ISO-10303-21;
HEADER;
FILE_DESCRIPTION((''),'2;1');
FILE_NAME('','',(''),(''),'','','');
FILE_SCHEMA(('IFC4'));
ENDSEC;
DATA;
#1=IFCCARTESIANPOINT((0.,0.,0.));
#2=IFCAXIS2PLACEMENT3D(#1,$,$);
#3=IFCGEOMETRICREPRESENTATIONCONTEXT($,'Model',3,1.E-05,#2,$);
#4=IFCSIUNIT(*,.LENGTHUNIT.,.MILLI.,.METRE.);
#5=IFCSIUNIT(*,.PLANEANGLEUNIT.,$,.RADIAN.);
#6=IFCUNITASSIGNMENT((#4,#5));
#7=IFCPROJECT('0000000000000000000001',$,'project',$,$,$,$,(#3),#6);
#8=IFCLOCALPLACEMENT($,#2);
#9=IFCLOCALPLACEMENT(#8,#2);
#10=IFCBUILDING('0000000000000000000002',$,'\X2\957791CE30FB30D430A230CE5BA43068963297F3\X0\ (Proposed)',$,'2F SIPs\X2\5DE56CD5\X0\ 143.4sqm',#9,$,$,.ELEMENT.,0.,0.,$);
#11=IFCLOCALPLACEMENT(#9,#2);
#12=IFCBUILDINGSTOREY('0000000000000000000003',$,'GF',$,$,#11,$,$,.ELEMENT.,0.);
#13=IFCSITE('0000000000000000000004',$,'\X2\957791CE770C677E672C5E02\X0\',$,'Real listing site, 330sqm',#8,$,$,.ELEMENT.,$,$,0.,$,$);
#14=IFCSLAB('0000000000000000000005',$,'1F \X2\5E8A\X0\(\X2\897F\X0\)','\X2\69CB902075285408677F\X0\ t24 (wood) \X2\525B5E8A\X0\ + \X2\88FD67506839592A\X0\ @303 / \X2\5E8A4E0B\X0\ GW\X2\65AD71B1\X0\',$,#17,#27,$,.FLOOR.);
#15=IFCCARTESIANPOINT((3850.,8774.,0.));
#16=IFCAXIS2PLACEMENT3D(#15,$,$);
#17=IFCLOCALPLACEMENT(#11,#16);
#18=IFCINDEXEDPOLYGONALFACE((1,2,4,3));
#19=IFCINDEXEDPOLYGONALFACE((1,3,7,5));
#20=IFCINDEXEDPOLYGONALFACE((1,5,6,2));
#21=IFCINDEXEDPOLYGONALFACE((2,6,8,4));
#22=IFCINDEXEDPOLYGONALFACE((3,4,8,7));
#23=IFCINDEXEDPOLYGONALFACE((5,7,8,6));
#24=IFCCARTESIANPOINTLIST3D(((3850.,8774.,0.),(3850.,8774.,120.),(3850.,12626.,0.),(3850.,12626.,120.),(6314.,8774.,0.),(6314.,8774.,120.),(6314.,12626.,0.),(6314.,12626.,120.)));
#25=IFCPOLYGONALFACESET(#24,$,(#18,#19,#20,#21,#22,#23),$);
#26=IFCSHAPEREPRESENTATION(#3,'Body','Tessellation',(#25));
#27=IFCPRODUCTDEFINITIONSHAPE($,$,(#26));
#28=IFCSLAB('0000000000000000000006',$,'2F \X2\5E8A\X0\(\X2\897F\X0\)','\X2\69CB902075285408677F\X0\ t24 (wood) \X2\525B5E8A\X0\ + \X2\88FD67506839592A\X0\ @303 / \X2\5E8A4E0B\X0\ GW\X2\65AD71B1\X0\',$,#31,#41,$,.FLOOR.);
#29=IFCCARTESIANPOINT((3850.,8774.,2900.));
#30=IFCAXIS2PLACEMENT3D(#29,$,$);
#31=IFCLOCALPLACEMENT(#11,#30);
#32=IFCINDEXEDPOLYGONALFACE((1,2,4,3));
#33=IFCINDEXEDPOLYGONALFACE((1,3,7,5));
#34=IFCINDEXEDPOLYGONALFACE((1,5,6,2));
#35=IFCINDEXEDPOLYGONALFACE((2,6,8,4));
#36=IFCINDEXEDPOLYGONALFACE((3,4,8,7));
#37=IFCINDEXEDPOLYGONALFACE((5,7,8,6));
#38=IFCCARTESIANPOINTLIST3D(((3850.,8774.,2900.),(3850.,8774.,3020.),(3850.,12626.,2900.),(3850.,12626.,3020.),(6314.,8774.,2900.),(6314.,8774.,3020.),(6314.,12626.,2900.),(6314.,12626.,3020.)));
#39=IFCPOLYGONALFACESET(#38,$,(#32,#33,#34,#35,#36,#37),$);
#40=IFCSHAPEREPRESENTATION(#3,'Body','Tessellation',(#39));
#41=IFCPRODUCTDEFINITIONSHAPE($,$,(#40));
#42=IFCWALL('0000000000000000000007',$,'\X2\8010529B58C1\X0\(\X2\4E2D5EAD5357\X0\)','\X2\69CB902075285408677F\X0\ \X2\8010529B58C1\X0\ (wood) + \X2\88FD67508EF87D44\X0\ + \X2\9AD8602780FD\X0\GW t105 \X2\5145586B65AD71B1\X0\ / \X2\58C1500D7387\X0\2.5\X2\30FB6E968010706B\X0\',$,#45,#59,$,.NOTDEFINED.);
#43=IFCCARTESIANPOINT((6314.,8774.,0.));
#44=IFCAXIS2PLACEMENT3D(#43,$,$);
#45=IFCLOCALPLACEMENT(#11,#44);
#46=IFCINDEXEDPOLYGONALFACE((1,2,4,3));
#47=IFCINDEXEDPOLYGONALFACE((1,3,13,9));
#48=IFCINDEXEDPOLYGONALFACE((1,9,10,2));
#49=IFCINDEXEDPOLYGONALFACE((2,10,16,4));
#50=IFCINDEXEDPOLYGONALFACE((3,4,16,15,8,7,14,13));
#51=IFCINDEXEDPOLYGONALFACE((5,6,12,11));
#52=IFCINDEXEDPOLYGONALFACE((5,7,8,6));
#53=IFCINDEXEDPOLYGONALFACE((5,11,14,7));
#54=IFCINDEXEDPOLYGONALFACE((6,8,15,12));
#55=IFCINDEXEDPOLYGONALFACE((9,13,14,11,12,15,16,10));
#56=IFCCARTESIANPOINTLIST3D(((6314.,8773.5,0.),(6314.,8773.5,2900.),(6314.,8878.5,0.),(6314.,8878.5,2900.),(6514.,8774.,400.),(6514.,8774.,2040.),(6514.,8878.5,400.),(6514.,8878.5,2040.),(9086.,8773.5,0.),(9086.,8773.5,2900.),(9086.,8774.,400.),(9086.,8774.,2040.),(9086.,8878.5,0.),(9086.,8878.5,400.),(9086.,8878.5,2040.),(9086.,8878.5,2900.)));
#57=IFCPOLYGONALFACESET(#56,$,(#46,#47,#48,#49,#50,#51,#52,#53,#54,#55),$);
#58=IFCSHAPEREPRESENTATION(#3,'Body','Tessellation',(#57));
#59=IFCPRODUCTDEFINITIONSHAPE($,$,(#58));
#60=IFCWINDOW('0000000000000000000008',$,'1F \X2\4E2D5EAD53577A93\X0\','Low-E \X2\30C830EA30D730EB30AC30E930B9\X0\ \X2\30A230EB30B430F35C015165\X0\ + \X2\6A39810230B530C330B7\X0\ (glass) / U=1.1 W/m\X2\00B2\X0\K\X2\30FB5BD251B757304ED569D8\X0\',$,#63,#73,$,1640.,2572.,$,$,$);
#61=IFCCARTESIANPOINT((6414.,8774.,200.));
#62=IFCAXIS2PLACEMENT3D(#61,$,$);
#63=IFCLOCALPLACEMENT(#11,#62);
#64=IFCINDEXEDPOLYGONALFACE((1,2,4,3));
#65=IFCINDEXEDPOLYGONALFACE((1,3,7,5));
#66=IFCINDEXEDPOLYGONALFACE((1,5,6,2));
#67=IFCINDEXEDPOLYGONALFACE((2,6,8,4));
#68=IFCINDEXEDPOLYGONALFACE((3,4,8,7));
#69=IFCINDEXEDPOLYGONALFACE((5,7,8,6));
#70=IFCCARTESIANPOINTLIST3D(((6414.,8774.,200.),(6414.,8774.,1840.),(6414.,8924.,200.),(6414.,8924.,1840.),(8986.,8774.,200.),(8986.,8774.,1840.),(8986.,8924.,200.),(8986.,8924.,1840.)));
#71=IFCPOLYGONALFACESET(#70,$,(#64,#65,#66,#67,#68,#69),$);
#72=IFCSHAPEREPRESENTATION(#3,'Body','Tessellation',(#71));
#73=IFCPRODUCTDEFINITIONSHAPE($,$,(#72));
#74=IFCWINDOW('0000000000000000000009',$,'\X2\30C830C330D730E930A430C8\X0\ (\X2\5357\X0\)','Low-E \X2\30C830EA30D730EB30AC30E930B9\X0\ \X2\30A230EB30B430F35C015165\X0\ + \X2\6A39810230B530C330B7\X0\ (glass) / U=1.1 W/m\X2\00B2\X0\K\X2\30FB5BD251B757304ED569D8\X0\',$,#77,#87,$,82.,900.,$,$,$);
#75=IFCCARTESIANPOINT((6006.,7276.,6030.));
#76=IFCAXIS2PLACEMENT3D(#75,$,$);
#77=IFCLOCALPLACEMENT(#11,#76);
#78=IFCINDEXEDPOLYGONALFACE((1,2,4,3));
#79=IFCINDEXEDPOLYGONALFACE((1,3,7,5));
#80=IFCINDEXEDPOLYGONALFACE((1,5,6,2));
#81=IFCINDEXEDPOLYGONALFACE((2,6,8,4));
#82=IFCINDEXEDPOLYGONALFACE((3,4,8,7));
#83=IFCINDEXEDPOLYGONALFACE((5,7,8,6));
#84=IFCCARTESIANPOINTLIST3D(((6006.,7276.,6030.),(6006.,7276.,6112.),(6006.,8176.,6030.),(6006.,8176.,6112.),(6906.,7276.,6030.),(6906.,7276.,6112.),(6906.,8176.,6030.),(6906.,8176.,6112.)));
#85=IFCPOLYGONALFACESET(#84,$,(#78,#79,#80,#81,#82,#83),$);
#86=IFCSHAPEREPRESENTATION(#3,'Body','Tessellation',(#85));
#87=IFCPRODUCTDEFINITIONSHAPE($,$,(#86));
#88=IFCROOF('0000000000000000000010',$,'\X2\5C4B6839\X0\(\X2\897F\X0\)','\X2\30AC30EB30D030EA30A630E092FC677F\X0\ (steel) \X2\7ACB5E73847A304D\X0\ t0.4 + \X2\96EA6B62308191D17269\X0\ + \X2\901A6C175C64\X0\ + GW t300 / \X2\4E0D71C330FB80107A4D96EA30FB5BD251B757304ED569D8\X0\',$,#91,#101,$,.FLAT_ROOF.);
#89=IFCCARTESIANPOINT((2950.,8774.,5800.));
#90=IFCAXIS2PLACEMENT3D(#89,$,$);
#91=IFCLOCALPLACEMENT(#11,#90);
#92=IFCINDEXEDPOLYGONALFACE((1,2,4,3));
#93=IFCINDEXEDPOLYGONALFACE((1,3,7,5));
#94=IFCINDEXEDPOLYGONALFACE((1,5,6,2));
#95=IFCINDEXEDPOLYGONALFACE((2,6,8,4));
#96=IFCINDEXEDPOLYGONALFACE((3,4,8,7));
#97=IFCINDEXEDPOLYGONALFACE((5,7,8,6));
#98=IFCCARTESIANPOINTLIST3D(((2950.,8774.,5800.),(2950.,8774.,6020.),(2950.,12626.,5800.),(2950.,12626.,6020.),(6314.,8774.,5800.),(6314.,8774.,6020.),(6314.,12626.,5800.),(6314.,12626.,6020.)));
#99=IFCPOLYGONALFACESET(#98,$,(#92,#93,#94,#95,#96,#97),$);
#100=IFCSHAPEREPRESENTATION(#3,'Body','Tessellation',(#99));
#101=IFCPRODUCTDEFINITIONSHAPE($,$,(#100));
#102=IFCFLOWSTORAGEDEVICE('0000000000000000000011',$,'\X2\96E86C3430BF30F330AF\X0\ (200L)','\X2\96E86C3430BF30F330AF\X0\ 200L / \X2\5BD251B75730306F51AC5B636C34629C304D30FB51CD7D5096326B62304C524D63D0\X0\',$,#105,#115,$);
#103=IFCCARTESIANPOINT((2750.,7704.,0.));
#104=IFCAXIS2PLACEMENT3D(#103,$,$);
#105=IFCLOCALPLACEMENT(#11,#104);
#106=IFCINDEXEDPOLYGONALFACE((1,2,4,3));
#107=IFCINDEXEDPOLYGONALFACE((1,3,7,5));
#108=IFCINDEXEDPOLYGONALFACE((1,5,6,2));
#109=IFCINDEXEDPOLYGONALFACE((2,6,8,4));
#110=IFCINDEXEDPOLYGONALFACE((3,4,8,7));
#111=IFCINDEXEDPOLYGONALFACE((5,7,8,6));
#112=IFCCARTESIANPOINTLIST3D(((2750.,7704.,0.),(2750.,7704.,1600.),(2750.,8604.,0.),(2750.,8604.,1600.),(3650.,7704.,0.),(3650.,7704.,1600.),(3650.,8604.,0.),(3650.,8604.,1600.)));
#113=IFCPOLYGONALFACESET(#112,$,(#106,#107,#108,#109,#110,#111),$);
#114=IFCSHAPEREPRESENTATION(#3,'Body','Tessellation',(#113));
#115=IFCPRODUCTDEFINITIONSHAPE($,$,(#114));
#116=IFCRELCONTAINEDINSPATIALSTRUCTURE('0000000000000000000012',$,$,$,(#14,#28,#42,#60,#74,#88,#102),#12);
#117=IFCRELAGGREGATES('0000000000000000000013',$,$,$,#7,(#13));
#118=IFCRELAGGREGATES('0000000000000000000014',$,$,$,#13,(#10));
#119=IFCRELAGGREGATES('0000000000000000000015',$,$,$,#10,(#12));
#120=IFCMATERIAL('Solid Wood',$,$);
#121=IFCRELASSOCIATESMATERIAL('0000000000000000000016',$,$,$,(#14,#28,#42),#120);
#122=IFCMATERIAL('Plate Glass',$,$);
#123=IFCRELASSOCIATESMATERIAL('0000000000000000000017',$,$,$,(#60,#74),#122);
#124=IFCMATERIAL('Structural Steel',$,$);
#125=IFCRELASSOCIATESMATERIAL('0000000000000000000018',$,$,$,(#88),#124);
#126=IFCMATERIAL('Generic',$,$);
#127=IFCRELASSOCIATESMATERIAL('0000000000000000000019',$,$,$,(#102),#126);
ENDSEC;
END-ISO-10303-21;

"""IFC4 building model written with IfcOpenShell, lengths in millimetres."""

from ifc_helpers import new_model, si_unit, frame, frame_2d, origin, place, context, project, spatial, rectangle, extrude, material, element, fill, save


model = new_model("IFC4")

# Units and contexts
model_context = context("Model", 3, precision=1e-05, world=origin())
ifc_project = project(units=[si_unit("LENGTHUNIT", "METRE", prefix="MILLI"), si_unit("PLANEANGLEUNIT", "RADIAN")], contexts=[model_context])

# Site, building, storey
site_placement = place(None, origin())
site = spatial("IfcSite", under=ifc_project, at=site_placement, Name="長野県松本市", ObjectType="Real listing site, 330sqm", CompositionType="ELEMENT", RefElevation=0.0)
building_placement = place(site_placement, origin())
building = spatial("IfcBuilding", under=site, at=building_placement, Name="長野・ピアノ室と防音 (Proposed)", ObjectType="2F SIPs工法 143.4sqm", CompositionType="ELEMENT", ElevationOfRefHeight=0.0, ElevationOfTerrain=0.0)
storey_placement = place(building_placement, origin())
storey = spatial("IfcBuildingStorey", under=building, at=storey_placement, Name="GF", CompositionType="ELEMENT", Elevation=0.0)

# Shared definitions
ifc_material_1 = material(Name="Solid Wood")

# Slabs
slab_1_placement = place(storey_placement, frame((3850.0, 8774.0, 0.0)))
element("IfcSlab", 1, at=slab_1_placement, inside=storey, material=ifc_material_1, Name="1F 床(西)", Description="構造用合板 t24 (wood) 剛床 + 製材根太 @303 / 床下 GW断熱", PredefinedType="FLOOR", context=model_context, shape_type="SweptSolid", body=[
    extrude(rectangle(XDim=2464.0, YDim=3852.0, at=frame_2d((1232.0, 1926.0))), frame((3850.0, 8774.0, 0.0)), (0.0, 0.0, 1.0), 120.0),
])
slab_2_placement = place(storey_placement, frame((3850.0, 8774.0, 2900.0)))
element("IfcSlab", 2, at=slab_2_placement, inside=storey, material=ifc_material_1, Name="2F 床(西)", Description="構造用合板 t24 (wood) 剛床 + 製材根太 @303 / 床下 GW断熱", PredefinedType="FLOOR", context=model_context, shape_type="SweptSolid", body=[
    extrude(rectangle(XDim=2464.0, YDim=3852.0, at=frame_2d((1232.0, 1926.0))), frame((3850.0, 8774.0, 2900.0)), (0.0, 0.0, 1.0), 120.0),
])

# Wall, opening, window
wall_placement = place(storey_placement, frame((6314.0, 8774.0, 0.0)))
wall = element("IfcWall", 3, at=wall_placement, inside=storey, material=ifc_material_1, Name="耐力壁(中庭南)", Description="構造用合板 耐力壁 (wood) + 製材軸組 + 高性能GW t105 充填断熱 / 壁倍率2.5・準耐火", PredefinedType="NOTDEFINED", context=model_context, shape_type="SweptSolid", body=[
    extrude(rectangle(XDim=2772.0, YDim=105.0, at=frame_2d((1386.0, 52.0))), frame((6314.0, 8774.0, 0.0)), (0.0, 0.0, 1.0), 2900.0),
])
opening_placement = place(storey_placement, frame((6414.0, 8774.0, 200.0)))
opening = element("IfcOpeningElement", 4, at=opening_placement, cuts=wall, PredefinedType="NOTDEFINED", context=model_context, shape_type="SweptSolid", body=[
    extrude(rectangle(XDim=2572.0, YDim=150.0, at=frame_2d((1286.0, 75.0))), frame((6414.0, 8774.0, 200.0)), (0.0, 0.0, 1.0), 1640.0),
])
ifc_material_2 = material(Name="Plate Glass")
window_1_placement = place(storey_placement, frame((6414.0, 8774.0, 200.0)))
window_1 = element("IfcWindow", 5, at=window_1_placement, inside=storey, material=ifc_material_2, Name="1F 中庭南窓", Description="Low-E トリプルガラス アルゴン封入 + 樹脂サッシ (glass) / U=1.1 W/m²K・寒冷地仕様", OverallHeight=1640.0, OverallWidth=2572.0, context=model_context, shape_type="SweptSolid", body=[
    extrude(rectangle(XDim=2572.0, YDim=150.0, at=frame_2d((1286.0, 75.0))), frame((6414.0, 8774.0, 200.0)), (0.0, 0.0, 1.0), 1640.0),
])
fill(opening, window_1)

# Window
window_2_placement = place(storey_placement, frame((6006.0, 7276.0, 6030.0)))
element("IfcWindow", 6, at=window_2_placement, inside=storey, material=ifc_material_2, Name="トップライト (南)", Description="Low-E トリプルガラス アルゴン封入 + 樹脂サッシ (glass) / U=1.1 W/m²K・寒冷地仕様", OverallHeight=82.0, OverallWidth=900.0, context=model_context, shape_type="SweptSolid", body=[
    extrude(rectangle(XDim=900.0, YDim=900.0, at=frame_2d((450.0, 450.0))), frame((6006.0, 7276.0, 6030.0)), (0.0, 0.0, 1.0), 82.0),
])

# Roof
ifc_material_3 = material(Name="Structural Steel")
for number, where, name in (
    (7, (2950.0, 8774.0, 5800.0), "屋根(西)"),
):
    element("IfcRoof", number, at=place(storey_placement, frame(where)), inside=storey, material=ifc_material_3, Name=name, Description="ガルバリウム鋼板 (steel) 立平葺き t0.4 + 雪止め金物 + 通気層 + GW t300 / 不燃・耐積雪・寒冷地仕様", PredefinedType="FLAT_ROOF", context=model_context, shape_type="SweptSolid", body=[
        extrude(rectangle(XDim=3364.0, YDim=3852.0, at=frame_2d((1682.0, 1926.0))), frame((2950.0, 8774.0, 5800.0)), (0.0, 0.0, 1.0), 220.0),
    ])

# Flow storage device
ifc_material_4 = material(Name="Generic")
flow_storage_device_placement = place(storey_placement, frame((2750.0, 7704.0, 0.0)))
element("IfcFlowStorageDevice", 8, at=flow_storage_device_placement, inside=storey, material=ifc_material_4, Name="雨水タンク (200L)", Description="雨水タンク 200L / 寒冷地は冬季水抜き・凍結防止が前提", context=model_context, shape_type="SweptSolid", body=[
    extrude(rectangle(XDim=900.0, YDim=900.0, at=frame_2d((450.0, 450.0))), frame((2750.0, 7704.0, 0.0)), (0.0, 0.0, 1.0), 1600.0),
])

save(model, "model.ifc")
